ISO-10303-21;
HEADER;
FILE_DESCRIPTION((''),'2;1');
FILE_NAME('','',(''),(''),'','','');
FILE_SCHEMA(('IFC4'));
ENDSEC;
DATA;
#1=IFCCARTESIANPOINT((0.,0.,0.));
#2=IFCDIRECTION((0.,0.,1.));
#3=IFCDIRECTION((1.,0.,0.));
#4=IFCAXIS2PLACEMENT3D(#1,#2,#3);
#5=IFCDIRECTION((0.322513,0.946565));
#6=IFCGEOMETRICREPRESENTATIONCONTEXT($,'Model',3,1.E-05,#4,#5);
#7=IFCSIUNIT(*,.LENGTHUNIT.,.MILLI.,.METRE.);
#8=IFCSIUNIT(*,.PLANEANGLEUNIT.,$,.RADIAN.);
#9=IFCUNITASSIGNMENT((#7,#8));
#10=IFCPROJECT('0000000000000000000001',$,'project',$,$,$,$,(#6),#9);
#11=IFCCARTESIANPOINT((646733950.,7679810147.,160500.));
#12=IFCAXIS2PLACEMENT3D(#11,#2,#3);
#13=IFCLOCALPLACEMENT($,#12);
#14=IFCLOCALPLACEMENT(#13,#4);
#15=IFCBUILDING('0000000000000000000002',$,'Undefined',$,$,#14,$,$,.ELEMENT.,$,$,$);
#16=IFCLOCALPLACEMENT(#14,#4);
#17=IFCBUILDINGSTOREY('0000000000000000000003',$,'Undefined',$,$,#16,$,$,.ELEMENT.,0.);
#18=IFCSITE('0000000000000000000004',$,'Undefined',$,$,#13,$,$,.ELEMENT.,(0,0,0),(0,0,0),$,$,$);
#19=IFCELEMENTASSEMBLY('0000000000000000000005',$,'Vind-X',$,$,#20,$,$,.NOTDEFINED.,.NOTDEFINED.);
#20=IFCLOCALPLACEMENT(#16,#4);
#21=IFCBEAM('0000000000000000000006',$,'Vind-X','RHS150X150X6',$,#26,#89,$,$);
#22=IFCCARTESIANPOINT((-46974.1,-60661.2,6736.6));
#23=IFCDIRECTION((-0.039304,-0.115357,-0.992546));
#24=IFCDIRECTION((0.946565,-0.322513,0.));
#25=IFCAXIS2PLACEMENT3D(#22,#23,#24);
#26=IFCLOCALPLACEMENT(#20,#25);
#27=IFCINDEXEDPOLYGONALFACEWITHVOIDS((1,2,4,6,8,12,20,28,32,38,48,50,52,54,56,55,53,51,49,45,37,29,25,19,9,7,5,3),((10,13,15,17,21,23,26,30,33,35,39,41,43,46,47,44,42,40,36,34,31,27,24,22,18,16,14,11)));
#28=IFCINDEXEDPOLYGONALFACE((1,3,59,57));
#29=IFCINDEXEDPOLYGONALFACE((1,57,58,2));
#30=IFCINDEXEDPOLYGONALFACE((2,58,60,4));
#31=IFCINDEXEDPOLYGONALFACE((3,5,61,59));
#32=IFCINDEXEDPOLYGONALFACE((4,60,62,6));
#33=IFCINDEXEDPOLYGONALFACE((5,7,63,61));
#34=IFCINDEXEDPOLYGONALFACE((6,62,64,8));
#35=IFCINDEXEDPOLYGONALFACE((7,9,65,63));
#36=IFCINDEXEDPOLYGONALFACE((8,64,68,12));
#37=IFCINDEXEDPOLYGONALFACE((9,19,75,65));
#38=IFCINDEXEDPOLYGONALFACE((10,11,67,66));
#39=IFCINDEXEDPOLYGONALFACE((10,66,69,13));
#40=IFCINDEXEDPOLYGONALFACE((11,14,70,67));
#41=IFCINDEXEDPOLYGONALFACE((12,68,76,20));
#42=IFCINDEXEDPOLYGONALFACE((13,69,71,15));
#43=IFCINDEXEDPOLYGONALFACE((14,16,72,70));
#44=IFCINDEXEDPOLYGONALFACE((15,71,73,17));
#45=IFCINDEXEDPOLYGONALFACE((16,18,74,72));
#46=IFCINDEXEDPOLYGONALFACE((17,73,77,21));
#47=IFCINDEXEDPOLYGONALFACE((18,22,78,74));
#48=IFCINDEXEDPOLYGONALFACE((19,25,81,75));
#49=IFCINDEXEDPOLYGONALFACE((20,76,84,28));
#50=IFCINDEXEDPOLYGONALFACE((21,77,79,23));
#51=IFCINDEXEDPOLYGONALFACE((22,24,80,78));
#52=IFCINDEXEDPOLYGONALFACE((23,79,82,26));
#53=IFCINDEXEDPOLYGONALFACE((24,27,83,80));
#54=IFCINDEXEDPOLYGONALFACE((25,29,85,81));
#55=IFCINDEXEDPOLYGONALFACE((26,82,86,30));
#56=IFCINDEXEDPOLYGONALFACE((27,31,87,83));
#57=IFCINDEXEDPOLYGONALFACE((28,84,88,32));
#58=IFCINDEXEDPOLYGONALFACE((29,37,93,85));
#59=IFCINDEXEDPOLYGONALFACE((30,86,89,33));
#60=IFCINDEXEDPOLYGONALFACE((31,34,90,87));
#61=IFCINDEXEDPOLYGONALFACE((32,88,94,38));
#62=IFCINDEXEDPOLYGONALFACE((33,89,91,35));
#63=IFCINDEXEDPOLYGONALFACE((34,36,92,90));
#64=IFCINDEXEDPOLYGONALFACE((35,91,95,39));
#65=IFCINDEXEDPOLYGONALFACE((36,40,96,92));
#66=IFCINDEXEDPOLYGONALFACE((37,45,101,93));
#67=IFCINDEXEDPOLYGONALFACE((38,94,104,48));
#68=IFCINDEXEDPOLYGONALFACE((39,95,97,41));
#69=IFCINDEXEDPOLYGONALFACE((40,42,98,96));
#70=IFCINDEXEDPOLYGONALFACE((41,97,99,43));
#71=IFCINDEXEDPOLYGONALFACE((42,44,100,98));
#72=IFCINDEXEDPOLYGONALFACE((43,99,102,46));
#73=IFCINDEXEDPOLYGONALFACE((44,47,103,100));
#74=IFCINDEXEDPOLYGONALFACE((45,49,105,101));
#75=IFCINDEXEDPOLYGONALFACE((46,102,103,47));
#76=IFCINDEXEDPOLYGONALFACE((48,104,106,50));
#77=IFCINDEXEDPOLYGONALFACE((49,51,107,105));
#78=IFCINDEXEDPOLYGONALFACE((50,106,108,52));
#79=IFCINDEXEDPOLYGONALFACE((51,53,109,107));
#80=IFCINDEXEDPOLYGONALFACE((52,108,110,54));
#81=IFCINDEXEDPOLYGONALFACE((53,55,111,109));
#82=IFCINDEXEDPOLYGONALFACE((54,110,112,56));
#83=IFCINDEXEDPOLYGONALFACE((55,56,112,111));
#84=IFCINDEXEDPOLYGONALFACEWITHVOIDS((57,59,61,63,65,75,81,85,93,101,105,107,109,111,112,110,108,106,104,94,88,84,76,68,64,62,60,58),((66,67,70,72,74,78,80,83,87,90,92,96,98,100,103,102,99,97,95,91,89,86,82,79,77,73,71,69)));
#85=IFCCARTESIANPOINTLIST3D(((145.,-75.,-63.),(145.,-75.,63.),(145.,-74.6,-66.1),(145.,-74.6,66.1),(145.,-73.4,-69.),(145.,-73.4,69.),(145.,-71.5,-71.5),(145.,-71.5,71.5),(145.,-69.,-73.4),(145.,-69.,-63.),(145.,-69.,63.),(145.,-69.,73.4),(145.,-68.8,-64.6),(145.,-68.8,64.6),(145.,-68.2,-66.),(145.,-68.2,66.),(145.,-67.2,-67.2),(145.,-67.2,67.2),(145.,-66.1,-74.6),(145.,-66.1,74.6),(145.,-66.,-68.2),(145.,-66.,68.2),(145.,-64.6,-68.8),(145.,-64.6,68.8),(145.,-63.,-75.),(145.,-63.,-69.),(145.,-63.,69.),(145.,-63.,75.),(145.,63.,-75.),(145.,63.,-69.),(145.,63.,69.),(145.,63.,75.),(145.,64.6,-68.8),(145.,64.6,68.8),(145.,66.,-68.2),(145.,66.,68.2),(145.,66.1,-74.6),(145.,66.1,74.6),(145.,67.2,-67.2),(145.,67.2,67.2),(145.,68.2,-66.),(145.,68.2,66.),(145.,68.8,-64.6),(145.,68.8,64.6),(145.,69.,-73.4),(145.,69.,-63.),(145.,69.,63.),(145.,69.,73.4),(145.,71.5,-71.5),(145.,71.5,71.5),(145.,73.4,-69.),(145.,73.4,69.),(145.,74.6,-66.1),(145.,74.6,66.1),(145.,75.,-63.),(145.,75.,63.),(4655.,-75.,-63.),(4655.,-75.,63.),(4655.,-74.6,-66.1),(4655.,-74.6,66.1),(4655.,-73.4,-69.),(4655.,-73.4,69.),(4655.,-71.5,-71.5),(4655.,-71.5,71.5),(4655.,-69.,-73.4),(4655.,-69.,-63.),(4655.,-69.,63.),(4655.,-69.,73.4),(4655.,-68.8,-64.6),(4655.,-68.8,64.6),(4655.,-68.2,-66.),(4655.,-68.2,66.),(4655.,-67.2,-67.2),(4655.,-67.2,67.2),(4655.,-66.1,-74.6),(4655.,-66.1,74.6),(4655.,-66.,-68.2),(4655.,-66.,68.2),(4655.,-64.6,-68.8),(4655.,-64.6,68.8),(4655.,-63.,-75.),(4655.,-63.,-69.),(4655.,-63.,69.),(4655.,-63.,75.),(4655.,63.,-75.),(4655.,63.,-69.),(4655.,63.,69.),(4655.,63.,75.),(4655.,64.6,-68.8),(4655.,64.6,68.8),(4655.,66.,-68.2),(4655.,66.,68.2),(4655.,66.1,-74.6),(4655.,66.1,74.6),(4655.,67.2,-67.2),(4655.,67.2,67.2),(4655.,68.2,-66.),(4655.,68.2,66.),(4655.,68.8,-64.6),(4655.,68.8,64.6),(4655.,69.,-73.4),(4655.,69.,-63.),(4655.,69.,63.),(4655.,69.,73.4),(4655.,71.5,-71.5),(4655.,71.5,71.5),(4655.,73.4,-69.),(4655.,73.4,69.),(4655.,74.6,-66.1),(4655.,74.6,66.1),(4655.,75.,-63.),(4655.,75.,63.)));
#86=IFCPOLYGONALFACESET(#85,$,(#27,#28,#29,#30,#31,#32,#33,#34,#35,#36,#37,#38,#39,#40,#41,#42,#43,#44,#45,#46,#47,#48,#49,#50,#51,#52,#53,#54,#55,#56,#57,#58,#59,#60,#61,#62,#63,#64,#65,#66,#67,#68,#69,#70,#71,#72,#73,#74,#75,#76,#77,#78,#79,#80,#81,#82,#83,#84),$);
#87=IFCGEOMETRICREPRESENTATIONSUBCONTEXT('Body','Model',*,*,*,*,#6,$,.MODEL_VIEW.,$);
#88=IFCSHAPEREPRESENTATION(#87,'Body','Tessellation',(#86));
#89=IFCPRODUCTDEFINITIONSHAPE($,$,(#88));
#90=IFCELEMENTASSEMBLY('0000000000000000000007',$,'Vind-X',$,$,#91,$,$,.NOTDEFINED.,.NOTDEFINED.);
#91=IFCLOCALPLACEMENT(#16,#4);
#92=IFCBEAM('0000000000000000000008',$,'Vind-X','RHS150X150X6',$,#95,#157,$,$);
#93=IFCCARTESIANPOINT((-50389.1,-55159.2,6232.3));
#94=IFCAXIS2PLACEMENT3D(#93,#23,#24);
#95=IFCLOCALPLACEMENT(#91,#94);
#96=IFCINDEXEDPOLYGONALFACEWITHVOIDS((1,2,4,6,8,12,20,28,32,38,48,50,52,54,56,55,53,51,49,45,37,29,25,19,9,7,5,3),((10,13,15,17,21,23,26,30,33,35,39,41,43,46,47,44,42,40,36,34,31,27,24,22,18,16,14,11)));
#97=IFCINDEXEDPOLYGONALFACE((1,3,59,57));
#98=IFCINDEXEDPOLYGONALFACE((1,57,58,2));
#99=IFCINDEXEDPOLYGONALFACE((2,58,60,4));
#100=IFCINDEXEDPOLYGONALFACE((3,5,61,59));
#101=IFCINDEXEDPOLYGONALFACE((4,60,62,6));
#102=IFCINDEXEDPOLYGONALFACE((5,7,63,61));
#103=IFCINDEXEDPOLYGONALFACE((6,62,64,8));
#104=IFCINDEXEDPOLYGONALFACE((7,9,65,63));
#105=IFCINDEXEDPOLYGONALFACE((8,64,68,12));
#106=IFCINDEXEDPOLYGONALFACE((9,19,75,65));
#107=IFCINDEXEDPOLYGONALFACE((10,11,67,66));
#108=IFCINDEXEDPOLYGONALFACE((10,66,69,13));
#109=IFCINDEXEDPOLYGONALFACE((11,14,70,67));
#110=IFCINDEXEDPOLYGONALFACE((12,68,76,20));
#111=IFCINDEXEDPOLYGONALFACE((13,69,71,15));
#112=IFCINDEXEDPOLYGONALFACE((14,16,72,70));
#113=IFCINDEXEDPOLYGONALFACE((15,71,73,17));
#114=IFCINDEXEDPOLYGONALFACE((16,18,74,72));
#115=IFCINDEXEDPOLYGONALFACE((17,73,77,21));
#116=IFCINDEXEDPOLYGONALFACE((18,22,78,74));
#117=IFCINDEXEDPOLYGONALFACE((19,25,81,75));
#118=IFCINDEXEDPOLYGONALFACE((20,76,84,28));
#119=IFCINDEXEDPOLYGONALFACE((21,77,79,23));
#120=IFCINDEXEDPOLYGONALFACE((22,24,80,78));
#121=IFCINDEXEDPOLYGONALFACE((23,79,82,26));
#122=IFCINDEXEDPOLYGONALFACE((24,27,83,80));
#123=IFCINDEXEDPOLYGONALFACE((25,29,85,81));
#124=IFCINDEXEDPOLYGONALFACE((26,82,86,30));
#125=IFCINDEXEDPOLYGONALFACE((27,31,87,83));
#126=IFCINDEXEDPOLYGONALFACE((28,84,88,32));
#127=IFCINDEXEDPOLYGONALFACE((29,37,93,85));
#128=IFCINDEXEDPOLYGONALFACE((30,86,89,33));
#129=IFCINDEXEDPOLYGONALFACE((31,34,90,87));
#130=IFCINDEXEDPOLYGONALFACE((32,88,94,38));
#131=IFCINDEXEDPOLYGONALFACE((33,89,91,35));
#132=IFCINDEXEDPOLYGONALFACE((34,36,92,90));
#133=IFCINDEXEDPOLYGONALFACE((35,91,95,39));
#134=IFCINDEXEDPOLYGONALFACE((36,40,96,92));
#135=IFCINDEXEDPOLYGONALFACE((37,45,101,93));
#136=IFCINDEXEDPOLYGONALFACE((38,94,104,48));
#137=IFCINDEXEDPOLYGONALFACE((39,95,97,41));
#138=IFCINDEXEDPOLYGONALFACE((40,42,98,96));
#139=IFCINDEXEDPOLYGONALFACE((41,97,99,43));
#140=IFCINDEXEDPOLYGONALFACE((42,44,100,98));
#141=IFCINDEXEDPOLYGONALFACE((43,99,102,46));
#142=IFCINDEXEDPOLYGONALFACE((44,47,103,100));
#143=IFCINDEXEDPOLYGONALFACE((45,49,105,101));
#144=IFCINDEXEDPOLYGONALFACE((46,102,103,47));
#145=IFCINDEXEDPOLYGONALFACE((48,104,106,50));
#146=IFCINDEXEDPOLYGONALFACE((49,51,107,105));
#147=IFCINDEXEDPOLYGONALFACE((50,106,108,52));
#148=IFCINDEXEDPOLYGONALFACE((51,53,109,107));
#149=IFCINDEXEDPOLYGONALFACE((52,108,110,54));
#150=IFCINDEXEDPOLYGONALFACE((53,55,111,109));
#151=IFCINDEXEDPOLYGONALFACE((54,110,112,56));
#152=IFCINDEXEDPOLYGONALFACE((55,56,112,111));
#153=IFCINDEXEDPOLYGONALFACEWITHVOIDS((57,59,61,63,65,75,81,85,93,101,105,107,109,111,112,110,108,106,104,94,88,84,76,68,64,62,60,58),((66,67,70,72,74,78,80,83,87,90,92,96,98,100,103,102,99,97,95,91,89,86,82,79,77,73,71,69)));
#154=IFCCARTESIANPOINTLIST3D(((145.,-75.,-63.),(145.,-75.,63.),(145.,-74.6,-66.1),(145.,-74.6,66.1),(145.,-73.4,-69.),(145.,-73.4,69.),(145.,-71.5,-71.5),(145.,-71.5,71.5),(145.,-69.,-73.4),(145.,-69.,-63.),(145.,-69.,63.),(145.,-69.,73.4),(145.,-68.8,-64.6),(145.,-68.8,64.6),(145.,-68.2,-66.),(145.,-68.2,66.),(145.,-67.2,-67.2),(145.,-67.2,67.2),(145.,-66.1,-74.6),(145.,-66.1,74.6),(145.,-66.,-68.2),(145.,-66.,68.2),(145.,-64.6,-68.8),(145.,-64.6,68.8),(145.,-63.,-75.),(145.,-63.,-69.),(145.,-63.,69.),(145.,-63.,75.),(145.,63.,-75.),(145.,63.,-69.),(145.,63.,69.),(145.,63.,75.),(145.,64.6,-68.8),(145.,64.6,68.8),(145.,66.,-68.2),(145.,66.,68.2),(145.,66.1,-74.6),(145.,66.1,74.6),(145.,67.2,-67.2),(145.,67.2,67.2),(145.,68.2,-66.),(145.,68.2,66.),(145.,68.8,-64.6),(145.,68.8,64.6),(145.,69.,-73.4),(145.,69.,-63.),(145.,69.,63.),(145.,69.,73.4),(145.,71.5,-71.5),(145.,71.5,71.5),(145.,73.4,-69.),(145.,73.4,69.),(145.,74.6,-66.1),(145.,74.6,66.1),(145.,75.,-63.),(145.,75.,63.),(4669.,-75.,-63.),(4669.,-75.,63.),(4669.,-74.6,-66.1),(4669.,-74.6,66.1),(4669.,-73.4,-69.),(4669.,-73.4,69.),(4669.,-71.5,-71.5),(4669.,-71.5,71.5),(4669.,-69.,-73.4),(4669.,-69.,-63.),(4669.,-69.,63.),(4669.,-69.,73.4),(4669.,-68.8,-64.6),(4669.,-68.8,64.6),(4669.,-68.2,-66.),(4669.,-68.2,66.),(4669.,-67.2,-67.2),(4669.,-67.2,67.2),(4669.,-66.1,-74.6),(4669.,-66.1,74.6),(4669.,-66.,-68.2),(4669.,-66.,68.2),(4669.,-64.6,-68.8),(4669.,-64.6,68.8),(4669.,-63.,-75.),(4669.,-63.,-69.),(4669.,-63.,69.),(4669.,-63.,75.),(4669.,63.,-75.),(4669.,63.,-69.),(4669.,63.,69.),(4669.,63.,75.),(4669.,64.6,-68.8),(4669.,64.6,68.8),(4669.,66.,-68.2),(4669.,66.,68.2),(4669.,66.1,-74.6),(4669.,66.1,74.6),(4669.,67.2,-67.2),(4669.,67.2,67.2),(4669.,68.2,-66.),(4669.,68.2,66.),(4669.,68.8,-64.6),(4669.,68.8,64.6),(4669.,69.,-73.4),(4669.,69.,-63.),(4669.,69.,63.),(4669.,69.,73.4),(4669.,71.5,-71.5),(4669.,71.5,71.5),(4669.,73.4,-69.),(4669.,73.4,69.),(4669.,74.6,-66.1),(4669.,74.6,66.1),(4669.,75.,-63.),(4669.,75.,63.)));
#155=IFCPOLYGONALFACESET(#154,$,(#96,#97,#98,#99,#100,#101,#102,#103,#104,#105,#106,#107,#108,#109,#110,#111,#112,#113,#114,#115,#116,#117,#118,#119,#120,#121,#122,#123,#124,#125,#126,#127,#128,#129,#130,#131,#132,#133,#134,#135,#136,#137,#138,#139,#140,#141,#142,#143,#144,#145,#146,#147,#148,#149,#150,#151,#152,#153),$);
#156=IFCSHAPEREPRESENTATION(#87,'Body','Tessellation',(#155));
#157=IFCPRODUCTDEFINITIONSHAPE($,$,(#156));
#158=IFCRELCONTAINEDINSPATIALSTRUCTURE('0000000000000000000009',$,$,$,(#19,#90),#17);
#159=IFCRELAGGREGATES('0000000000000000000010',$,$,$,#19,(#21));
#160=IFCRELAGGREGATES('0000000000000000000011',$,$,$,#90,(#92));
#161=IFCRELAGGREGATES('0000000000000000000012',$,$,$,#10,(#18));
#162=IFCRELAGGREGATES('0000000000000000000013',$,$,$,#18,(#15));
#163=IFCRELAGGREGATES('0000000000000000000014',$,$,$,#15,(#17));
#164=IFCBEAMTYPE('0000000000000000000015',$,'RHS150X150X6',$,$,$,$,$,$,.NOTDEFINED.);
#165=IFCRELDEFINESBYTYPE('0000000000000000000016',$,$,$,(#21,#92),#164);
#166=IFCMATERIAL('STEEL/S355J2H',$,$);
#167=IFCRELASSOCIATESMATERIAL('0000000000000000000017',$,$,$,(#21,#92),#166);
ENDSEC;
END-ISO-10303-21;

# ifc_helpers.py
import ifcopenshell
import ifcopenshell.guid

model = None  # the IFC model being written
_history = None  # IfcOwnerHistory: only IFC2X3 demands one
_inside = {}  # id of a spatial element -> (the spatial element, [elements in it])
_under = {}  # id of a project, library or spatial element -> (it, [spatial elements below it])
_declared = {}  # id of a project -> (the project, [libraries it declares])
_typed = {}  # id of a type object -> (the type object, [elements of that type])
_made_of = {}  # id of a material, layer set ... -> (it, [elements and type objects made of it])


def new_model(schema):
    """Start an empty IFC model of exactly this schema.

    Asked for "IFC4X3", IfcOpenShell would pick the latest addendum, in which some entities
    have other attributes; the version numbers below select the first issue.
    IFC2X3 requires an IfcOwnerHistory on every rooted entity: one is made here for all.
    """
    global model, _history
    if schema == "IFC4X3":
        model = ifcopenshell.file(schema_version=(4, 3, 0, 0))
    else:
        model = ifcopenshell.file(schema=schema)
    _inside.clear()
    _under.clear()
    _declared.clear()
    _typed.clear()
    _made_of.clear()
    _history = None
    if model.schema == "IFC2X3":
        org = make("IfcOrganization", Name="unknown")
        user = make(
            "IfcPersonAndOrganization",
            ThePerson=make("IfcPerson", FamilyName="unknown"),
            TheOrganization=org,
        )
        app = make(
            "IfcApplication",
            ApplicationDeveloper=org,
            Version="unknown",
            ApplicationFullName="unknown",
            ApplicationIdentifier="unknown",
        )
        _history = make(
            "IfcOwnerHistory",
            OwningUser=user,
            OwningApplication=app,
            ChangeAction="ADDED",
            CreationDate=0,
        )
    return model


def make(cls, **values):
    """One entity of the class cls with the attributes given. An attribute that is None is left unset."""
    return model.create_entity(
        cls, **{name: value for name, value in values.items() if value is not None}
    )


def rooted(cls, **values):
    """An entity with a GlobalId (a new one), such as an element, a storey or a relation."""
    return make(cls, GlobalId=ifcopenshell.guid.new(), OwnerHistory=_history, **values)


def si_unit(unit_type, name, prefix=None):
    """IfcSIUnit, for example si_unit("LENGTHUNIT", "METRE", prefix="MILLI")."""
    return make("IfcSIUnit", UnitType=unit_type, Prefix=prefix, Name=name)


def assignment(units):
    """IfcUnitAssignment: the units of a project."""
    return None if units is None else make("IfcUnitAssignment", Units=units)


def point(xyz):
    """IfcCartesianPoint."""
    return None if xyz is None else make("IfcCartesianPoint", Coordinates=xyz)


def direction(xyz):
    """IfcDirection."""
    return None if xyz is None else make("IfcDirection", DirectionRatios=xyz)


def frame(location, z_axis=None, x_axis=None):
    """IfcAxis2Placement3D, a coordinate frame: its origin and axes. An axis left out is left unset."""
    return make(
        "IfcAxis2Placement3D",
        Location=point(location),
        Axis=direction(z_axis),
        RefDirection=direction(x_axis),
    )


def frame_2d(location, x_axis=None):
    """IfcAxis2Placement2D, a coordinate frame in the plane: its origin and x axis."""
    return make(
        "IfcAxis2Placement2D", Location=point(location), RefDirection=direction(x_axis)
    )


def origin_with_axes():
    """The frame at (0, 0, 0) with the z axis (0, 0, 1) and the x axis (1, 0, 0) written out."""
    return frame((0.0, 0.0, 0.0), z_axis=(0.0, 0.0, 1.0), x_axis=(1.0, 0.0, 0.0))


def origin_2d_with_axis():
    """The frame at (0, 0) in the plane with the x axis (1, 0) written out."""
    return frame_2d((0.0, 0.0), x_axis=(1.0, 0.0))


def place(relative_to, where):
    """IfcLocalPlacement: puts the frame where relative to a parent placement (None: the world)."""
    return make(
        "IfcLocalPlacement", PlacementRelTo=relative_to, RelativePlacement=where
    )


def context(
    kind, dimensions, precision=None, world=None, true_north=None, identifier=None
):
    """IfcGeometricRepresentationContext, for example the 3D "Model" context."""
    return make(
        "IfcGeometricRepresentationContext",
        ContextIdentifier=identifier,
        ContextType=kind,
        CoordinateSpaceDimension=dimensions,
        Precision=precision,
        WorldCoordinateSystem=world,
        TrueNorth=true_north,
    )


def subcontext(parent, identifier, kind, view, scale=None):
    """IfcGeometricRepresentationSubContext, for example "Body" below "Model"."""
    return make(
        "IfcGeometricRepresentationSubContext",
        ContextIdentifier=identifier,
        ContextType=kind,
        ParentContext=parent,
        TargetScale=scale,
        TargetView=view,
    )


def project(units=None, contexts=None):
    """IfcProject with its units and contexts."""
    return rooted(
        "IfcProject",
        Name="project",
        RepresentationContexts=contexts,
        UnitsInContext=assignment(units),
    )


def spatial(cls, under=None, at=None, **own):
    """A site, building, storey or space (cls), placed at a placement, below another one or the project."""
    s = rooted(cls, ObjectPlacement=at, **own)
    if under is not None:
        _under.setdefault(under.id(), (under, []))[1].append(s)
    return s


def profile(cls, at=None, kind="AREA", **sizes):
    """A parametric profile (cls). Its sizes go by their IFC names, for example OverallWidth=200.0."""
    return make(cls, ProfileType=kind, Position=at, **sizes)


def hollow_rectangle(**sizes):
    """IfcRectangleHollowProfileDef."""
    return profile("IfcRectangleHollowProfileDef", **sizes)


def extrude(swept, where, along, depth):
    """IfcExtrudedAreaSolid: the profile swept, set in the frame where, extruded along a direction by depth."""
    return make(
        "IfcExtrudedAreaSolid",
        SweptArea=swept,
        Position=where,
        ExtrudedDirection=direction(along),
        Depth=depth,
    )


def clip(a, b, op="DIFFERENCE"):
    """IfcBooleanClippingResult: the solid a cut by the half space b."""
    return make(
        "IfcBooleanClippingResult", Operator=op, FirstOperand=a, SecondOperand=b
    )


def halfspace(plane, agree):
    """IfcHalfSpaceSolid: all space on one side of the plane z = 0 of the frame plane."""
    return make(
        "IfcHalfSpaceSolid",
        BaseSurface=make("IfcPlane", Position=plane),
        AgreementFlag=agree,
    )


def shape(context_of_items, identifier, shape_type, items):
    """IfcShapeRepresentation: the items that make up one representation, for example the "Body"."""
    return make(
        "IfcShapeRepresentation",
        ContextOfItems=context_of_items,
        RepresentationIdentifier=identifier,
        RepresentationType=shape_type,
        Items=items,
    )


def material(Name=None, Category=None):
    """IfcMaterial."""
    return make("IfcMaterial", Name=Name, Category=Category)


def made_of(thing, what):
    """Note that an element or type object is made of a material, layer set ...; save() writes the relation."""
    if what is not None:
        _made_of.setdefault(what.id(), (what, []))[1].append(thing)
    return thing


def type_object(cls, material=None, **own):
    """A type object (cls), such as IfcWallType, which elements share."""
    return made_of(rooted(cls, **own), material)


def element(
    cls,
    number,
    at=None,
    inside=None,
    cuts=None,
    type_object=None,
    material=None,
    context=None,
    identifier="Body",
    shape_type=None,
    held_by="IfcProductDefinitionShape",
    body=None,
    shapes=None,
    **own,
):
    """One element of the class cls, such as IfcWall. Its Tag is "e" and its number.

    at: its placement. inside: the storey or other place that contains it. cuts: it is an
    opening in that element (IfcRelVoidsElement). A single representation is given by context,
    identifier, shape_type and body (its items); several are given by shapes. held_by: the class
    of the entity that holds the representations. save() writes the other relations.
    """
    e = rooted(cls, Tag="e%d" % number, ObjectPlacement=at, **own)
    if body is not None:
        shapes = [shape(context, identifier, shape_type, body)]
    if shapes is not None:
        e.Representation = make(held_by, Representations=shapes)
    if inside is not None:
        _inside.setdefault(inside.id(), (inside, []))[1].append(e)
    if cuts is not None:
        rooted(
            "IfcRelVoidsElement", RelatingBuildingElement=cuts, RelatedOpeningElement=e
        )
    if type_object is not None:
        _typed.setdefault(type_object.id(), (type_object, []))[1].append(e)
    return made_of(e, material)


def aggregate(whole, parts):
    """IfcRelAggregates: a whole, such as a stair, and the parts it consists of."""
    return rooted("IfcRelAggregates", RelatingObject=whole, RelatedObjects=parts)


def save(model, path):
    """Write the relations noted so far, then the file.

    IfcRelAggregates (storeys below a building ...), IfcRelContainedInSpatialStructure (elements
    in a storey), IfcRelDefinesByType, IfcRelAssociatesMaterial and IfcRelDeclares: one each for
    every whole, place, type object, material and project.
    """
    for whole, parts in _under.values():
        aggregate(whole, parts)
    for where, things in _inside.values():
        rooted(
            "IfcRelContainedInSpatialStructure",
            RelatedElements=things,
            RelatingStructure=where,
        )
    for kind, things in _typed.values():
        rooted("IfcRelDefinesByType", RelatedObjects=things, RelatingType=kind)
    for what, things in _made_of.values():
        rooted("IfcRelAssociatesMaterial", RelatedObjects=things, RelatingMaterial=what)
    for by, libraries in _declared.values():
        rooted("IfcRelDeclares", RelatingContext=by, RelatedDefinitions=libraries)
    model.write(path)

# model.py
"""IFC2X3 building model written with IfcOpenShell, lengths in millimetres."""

from ifc_helpers import new_model, si_unit, direction, frame, origin_with_axes, origin_2d_with_axis, place, context, subcontext, project, spatial, hollow_rectangle, extrude, clip, halfspace, material, type_object, element, aggregate, save


model = new_model("IFC2X3")

# Units and contexts
model_context = context("Model", 3, precision=1e-05, world=origin_with_axes(), true_north=direction((0.322513, 0.946565)))
body_context = subcontext(model_context, "Body", "Model", "MODEL_VIEW")
ifc_project = project(units=[si_unit("LENGTHUNIT", "METRE", prefix="MILLI"), si_unit("PLANEANGLEUNIT", "RADIAN")], contexts=[model_context])

# Site, building, storey
site_placement = place(None, frame((646733950.0, 7679810147.0, 160500.0), z_axis=(0.0, 0.0, 1.0), x_axis=(1.0, 0.0, 0.0)))
site = spatial("IfcSite", under=ifc_project, at=site_placement, Name="Undefined", CompositionType="ELEMENT", RefLatitude=(0, 0, 0), RefLongitude=(0, 0, 0))
building_placement = place(site_placement, origin_with_axes())
building = spatial("IfcBuilding", under=site, at=building_placement, Name="Undefined", CompositionType="ELEMENT")
storey_placement = place(building_placement, origin_with_axes())
storey = spatial("IfcBuildingStorey", under=building, at=storey_placement, Name="Undefined", CompositionType="ELEMENT", Elevation=0.0)

# Shared definitions
ifc_material_1 = material(Name="STEEL/S355J2H")

# Element assemblies, beams
assembly_1_placement = place(storey_placement, origin_with_axes())
assembly_1 = element("IfcElementAssembly", 1, at=assembly_1_placement, inside=storey, Name="Vind-X", AssemblyPlace="NOTDEFINED", PredefinedType="NOTDEFINED")
beam_type_1 = type_object("IfcBeamType", Name="RHS150X150X6", PredefinedType="NOTDEFINED")
beam_1_placement = place(assembly_1_placement, frame((-46974.1, -60661.2, 6736.6), z_axis=(-0.039304, -0.115357, -0.992546), x_axis=(0.946565, -0.322513, 0.0)))
beam_1 = element("IfcBeam", 2, at=beam_1_placement, type_object=beam_type_1, material=ifc_material_1, Name="Vind-X", Description="RHS150X150X6", context=body_context, shape_type="Clipping", body=[
    clip(clip(extrude(hollow_rectangle(XDim=150.0, YDim=150.0, WallThickness=6.0, InnerFilletRadius=6.0, OuterFilletRadius=12.0, at=origin_2d_with_axis()), frame((4800.0, 0.0, 0.0), z_axis=(-1.0, 0.0, 0.0), x_axis=(0.0, -1.0, 0.0)), (0.0, 0.0, 1.0), 4800.0), halfspace(frame((4655.0, 0.0, 0.0), z_axis=(-1.0, 0.0, 0.0), x_axis=(0.0, 1.0, 0.0)), True)), halfspace(frame((145.0, 0.0, 0.0), z_axis=(1.0, 0.0, 0.0), x_axis=(0.0, -1.0, 0.0)), True)),
])
assembly_2_placement = place(storey_placement, origin_with_axes())
assembly_2 = element("IfcElementAssembly", 3, at=assembly_2_placement, inside=storey, Name="Vind-X", AssemblyPlace="NOTDEFINED", PredefinedType="NOTDEFINED")
beam_2_placement = place(assembly_2_placement, frame((-50389.1, -55159.2, 6232.3), z_axis=(-0.039304, -0.115357, -0.992546), x_axis=(0.946565, -0.322513, 0.0)))
beam_2 = element("IfcBeam", 4, at=beam_2_placement, type_object=beam_type_1, material=ifc_material_1, Name="Vind-X", Description="RHS150X150X6", context=body_context, shape_type="Clipping", body=[
    clip(clip(extrude(hollow_rectangle(XDim=150.0, YDim=150.0, WallThickness=6.0, InnerFilletRadius=6.0, OuterFilletRadius=12.0, at=origin_2d_with_axis()), frame((4814.0, 0.0, 0.0), z_axis=(-1.0, 0.0, 0.0), x_axis=(0.0, -1.0, 0.0)), (0.0, 0.0, 1.0), 4814.0), halfspace(frame((4669.0, 0.0, 0.0), z_axis=(-1.0, 0.0, 0.0), x_axis=(0.0, 1.0, 0.0)), True)), halfspace(frame((145.0, 0.0, 0.0), z_axis=(1.0, 0.0, 0.0), x_axis=(0.0, -1.0, 0.0)), True)),
])

aggregate(assembly_1, [beam_1])
aggregate(assembly_2, [beam_2])

save(model, "model.ifc")
